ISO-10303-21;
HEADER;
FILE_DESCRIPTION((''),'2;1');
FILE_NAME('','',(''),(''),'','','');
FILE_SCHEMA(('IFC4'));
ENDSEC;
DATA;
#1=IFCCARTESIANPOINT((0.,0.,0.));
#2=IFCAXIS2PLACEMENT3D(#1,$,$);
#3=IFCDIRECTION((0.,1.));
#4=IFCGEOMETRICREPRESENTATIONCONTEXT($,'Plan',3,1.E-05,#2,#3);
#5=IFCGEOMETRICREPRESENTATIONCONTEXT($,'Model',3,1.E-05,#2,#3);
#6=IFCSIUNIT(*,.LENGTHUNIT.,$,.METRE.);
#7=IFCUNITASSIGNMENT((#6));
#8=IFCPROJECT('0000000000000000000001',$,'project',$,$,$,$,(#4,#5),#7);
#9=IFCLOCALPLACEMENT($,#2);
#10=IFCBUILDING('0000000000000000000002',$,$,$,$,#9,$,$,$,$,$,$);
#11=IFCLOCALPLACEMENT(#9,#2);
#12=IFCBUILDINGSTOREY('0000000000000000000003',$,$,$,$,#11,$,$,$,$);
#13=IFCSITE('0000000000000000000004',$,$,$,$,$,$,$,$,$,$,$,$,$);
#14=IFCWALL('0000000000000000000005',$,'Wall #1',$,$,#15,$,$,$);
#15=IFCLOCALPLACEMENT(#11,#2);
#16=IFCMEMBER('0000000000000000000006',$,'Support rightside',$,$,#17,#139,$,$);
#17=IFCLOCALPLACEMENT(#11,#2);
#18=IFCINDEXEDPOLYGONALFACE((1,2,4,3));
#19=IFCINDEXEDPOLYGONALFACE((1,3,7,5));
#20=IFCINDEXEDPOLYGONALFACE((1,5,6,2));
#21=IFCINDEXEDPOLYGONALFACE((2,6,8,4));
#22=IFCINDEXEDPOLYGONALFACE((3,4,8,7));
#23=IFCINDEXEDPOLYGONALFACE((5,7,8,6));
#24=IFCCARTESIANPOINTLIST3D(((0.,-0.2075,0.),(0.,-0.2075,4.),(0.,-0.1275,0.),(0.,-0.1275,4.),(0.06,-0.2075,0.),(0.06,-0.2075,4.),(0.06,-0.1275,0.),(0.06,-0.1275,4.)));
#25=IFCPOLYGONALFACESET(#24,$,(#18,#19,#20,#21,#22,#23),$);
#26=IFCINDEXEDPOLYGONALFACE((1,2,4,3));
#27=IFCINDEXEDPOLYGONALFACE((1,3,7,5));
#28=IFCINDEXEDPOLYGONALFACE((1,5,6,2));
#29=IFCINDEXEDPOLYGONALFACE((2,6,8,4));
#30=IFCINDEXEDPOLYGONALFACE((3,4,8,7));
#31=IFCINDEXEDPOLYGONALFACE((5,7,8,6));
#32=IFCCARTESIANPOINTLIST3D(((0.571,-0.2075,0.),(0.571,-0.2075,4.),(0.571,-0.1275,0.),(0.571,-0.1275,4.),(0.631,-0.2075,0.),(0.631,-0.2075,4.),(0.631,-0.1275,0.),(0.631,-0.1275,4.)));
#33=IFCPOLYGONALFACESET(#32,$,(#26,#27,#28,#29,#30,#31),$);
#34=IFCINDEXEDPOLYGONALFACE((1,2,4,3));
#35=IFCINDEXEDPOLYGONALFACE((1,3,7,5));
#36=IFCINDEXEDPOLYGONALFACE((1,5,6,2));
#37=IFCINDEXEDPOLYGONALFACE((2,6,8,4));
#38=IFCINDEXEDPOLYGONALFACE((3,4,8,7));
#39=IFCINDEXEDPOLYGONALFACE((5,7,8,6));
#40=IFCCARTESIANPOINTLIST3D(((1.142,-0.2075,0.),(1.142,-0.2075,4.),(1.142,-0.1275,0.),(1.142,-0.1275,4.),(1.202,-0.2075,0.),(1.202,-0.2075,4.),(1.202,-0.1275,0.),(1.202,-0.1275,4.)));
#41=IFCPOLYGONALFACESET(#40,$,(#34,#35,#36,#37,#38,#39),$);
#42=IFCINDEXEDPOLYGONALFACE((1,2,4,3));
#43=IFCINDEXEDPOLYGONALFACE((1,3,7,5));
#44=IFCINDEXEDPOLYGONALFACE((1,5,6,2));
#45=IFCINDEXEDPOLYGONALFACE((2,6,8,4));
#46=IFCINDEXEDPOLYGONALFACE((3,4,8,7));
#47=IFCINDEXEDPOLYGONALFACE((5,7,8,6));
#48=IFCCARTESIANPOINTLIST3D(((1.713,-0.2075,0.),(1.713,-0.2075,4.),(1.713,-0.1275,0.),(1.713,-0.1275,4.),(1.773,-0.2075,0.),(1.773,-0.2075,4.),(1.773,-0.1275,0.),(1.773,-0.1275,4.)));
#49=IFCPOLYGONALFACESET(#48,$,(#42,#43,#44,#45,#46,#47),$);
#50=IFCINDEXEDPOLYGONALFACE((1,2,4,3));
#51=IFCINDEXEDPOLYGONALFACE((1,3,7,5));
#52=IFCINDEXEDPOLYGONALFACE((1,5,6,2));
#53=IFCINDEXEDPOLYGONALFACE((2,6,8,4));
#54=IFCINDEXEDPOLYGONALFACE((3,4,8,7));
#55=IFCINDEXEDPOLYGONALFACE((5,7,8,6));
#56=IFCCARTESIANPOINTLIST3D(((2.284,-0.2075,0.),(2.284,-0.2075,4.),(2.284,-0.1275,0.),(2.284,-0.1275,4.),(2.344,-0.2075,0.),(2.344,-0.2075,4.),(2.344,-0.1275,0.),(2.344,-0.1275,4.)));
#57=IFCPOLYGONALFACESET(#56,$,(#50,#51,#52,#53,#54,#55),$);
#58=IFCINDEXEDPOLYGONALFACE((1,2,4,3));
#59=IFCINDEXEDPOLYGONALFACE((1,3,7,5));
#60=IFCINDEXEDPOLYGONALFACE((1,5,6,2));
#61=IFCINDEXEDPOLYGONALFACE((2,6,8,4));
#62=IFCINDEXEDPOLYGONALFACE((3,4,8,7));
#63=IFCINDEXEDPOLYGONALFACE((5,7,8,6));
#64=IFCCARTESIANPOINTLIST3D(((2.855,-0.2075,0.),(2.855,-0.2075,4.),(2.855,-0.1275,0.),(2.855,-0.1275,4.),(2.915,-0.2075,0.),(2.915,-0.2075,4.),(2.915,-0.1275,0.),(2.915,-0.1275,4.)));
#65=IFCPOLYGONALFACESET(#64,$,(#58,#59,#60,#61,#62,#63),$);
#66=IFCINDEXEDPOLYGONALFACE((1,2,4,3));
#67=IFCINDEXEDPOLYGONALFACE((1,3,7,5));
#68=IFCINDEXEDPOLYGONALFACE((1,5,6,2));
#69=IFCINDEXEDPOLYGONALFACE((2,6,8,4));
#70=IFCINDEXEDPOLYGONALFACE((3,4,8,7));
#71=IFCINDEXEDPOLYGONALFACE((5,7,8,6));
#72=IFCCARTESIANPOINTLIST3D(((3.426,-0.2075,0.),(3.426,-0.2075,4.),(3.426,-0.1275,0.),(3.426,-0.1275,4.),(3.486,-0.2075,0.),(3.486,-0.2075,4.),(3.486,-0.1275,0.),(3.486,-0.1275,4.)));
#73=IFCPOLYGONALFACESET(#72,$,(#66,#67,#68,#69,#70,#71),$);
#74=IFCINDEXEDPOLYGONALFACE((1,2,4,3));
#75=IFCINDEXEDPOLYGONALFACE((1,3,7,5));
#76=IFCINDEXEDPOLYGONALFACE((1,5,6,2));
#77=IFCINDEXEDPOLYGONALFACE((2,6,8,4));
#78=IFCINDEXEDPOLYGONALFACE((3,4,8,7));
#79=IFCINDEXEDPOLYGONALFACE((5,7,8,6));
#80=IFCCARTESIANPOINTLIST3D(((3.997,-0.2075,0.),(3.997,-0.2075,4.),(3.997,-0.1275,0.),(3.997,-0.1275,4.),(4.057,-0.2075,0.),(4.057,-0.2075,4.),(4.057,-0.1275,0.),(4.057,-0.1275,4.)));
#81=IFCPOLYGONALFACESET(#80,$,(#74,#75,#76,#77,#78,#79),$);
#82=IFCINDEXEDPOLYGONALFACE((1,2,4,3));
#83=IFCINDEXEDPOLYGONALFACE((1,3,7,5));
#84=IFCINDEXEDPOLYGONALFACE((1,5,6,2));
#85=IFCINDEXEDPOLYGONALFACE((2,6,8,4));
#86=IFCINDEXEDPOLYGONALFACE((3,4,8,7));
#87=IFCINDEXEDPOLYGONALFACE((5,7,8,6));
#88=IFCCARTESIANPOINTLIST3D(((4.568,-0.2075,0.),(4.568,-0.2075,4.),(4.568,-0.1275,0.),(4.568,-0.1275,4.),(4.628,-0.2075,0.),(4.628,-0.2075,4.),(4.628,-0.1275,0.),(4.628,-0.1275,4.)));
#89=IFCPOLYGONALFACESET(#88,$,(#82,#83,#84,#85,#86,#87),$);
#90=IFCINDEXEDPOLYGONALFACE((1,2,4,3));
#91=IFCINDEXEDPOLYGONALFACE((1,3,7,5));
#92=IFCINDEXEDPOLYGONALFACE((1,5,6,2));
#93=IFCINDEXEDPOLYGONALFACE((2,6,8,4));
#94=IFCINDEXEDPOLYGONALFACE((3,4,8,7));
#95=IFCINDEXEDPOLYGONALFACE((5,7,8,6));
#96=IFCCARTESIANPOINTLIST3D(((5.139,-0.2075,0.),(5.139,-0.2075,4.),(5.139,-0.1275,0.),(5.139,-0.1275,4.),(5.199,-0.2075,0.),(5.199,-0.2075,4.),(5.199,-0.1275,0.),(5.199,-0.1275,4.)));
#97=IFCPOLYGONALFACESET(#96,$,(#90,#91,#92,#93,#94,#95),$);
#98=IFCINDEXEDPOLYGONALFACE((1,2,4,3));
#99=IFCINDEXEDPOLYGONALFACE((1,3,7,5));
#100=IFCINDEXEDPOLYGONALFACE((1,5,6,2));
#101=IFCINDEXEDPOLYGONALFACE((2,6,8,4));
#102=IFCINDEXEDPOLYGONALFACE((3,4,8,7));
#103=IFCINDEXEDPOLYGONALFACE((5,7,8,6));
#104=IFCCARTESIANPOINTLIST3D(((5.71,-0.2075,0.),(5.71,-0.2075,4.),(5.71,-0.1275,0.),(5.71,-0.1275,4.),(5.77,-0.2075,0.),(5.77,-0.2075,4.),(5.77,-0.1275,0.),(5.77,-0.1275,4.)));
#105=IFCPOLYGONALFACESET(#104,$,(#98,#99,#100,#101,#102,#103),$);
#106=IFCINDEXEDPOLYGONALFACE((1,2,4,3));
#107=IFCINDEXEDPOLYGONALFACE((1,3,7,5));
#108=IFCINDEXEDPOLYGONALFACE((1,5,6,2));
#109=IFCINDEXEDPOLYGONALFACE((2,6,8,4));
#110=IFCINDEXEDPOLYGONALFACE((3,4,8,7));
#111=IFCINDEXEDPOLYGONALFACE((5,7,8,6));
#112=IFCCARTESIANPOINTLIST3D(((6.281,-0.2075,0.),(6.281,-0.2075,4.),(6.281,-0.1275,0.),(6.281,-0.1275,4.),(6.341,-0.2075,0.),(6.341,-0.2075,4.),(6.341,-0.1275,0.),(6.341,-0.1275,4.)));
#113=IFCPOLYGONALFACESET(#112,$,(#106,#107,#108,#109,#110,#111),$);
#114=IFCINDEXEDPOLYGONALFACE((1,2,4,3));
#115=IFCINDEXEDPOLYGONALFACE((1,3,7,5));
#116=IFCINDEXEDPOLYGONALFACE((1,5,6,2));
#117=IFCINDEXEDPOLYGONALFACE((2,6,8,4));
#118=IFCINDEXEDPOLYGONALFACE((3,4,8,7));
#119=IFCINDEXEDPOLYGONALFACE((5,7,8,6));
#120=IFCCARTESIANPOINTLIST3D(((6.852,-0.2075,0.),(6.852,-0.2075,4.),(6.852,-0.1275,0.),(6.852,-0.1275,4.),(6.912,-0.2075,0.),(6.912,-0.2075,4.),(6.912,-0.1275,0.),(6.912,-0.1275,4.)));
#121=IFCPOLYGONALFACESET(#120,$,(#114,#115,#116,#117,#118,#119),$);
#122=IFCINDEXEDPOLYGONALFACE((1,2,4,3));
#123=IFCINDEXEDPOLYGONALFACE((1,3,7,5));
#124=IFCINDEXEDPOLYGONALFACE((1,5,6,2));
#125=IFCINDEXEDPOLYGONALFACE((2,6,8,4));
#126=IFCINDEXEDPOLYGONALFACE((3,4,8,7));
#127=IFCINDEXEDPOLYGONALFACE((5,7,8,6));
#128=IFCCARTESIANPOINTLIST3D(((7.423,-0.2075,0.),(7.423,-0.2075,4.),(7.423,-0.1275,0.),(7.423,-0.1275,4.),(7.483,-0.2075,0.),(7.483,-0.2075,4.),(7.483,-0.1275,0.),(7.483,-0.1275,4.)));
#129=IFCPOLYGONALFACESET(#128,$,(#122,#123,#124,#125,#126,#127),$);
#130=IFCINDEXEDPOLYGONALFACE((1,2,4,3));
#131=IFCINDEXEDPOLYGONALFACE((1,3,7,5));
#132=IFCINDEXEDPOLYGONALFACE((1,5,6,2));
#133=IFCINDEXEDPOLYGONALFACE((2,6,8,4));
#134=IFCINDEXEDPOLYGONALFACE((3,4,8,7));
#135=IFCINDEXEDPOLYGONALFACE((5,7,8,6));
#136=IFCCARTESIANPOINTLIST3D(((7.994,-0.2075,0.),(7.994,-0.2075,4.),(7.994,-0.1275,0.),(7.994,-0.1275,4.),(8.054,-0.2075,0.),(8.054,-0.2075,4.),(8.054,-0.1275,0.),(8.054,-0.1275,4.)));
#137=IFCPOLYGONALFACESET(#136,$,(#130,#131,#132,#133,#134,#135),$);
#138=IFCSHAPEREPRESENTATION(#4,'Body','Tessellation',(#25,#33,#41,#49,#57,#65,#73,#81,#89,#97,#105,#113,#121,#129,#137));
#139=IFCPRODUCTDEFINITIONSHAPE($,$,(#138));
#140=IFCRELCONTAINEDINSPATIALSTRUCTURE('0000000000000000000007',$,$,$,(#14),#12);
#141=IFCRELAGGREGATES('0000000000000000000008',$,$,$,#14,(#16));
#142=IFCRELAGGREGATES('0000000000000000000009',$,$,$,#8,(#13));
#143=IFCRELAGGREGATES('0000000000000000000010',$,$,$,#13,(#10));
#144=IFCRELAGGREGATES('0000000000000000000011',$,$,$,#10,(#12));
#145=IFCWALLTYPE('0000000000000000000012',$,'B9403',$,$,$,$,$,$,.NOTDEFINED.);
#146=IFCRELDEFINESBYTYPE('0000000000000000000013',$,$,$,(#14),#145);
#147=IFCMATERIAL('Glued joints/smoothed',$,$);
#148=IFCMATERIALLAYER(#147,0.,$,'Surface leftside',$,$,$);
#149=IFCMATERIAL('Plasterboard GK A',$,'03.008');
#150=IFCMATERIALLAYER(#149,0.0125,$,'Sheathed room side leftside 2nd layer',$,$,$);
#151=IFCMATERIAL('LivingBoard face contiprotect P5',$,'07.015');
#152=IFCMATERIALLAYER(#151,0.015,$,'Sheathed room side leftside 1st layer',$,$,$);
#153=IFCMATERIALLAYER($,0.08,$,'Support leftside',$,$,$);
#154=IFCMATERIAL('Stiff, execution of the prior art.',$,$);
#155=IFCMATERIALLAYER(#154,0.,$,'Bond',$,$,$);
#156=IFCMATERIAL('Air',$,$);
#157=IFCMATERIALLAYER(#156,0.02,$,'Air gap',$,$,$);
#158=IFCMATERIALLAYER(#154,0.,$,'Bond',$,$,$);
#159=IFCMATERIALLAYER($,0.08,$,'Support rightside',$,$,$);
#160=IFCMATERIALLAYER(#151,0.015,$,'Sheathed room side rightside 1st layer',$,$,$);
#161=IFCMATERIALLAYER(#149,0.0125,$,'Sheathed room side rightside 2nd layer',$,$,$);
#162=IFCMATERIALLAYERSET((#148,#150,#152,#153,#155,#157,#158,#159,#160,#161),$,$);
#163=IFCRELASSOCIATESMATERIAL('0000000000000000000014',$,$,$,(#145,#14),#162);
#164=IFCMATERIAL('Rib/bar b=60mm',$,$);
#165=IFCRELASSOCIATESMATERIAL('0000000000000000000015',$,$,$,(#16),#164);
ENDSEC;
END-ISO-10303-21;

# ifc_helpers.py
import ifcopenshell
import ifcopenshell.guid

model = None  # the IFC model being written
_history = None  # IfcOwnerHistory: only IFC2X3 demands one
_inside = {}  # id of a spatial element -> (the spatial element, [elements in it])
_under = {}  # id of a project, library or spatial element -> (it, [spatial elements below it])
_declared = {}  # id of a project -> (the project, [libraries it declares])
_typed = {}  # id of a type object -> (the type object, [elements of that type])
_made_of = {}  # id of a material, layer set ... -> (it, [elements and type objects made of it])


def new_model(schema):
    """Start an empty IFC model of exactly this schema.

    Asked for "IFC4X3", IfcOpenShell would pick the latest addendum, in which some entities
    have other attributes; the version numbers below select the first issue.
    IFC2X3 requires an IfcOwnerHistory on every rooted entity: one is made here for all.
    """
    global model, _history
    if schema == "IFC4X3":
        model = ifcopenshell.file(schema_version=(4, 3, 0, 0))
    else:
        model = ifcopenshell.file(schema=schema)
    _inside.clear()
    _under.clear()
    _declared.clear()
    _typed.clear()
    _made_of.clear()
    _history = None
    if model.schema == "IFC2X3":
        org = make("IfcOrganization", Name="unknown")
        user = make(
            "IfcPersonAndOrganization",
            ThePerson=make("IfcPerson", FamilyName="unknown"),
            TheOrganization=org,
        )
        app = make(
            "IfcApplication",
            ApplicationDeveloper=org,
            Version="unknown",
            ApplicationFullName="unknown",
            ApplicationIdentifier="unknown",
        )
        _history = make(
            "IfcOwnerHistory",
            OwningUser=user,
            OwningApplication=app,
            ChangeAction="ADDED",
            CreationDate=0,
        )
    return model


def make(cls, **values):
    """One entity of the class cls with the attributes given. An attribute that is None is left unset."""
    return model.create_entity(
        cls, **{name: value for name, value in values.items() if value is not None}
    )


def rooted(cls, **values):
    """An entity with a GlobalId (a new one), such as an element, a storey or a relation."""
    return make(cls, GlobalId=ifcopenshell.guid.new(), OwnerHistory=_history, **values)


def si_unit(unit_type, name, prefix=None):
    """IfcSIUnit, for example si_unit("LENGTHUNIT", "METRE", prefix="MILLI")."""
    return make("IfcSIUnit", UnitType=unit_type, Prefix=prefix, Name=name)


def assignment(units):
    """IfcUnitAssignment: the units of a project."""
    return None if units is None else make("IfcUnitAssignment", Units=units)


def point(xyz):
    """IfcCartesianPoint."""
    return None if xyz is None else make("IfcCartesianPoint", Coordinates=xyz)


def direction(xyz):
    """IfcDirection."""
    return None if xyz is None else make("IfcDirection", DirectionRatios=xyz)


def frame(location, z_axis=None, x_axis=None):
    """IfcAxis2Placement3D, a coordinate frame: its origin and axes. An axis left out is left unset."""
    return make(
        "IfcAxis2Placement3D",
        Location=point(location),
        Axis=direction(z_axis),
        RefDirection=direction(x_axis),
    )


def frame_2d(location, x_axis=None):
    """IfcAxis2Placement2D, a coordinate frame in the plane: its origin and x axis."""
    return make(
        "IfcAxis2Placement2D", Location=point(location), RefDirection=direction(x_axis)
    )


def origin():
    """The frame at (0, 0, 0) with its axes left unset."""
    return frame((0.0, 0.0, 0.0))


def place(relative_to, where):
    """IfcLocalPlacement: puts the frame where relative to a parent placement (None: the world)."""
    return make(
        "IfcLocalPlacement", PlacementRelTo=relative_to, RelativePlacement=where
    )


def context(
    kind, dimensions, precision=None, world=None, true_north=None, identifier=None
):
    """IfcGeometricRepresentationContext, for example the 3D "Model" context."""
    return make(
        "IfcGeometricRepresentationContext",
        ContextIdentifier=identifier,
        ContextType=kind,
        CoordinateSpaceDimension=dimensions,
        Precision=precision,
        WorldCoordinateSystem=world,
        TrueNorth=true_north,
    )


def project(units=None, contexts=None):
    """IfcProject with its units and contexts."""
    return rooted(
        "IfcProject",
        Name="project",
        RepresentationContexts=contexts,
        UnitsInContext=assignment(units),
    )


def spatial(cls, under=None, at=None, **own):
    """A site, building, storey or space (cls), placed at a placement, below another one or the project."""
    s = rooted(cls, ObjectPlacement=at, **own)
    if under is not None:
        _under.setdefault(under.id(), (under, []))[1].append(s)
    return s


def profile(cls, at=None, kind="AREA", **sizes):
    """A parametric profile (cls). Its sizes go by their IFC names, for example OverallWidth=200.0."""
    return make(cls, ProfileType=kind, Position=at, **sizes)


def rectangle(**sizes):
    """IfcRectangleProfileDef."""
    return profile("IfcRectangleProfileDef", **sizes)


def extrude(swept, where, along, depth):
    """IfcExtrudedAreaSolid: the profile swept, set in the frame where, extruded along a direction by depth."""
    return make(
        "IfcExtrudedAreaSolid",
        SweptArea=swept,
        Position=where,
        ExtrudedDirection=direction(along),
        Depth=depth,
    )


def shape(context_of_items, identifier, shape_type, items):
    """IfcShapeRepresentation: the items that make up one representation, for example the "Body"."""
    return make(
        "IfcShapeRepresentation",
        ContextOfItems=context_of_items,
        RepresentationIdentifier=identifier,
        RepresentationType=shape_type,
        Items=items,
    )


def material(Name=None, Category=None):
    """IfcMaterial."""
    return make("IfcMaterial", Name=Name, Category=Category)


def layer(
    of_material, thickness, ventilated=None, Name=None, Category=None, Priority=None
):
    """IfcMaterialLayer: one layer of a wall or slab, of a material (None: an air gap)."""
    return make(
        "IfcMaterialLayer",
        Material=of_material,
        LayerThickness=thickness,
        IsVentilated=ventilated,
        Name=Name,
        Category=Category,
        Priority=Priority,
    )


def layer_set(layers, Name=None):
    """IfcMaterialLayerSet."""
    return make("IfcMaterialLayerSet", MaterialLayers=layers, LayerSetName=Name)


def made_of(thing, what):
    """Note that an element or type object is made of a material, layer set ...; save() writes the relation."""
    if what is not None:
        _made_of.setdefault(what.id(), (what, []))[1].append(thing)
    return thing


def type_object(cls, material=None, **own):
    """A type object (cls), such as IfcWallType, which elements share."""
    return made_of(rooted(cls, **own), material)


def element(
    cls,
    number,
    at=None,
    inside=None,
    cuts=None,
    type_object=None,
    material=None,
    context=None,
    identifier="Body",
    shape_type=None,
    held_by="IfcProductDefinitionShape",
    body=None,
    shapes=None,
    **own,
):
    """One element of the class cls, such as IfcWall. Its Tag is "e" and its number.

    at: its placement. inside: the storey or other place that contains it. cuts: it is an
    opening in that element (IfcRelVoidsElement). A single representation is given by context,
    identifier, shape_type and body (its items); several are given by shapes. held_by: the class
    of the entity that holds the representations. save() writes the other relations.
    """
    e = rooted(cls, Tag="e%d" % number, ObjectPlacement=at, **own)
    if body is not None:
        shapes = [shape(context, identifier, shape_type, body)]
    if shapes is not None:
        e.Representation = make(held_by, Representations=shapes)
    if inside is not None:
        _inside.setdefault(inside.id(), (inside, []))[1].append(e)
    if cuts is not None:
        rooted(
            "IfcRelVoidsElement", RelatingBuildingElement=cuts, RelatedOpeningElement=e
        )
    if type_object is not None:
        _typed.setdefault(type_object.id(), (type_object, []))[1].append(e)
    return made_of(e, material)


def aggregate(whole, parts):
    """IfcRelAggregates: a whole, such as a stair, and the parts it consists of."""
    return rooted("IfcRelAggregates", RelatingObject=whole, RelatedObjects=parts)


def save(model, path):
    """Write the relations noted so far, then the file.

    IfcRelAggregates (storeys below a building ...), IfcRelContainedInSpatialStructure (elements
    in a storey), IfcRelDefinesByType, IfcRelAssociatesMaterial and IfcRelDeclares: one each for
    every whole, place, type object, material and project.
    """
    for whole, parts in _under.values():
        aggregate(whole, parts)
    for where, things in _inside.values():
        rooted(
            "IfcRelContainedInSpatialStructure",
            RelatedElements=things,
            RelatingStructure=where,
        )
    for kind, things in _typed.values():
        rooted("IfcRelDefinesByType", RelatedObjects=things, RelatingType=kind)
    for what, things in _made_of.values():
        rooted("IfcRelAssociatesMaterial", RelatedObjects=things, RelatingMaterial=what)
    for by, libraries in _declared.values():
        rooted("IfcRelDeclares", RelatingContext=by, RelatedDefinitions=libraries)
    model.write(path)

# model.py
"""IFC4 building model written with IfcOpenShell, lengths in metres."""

from ifc_helpers import new_model, si_unit, direction, frame, frame_2d, origin, place, context, project, spatial, rectangle, extrude, material, layer, layer_set, type_object, element, aggregate, save


model = new_model("IFC4")

# Units and contexts
plan_context = context("Plan", 3, precision=1e-05, world=origin(), true_north=direction((0.0, 1.0)))
model_context = context("Model", 3, precision=1e-05, world=origin(), true_north=direction((0.0, 1.0)))
ifc_project = project(units=[si_unit("LENGTHUNIT", "METRE")], contexts=[plan_context, model_context])

# Site, building, storey
site = spatial("IfcSite", under=ifc_project)
building_placement = place(None, origin())
building = spatial("IfcBuilding", under=site, at=building_placement)
storey_placement = place(building_placement, origin())
storey = spatial("IfcBuildingStorey", under=building, at=storey_placement)

# Wall, member
ifc_material_1 = material(Name="Glued joints/smoothed")
ifc_layer_1 = layer(ifc_material_1, 0.0, Name="Surface leftside")
ifc_material_2 = material(Name="Plasterboard GK A", Category="03.008")
ifc_layer_2 = layer(ifc_material_2, 0.0125, Name="Sheathed room side leftside 2nd layer")
ifc_material_3 = material(Name="LivingBoard face contiprotect P5", Category="07.015")
ifc_layer_3 = layer(ifc_material_3, 0.015, Name="Sheathed room side leftside 1st layer")
ifc_layer_4 = layer(None, 0.08, Name="Support leftside")
ifc_material_4 = material(Name="Stiff, execution of the prior art.")
ifc_layer_5 = layer(ifc_material_4, 0.0, Name="Bond")
ifc_material_5 = material(Name="Air")
ifc_layer_6 = layer(ifc_material_5, 0.02, Name="Air gap")
ifc_layer_7 = layer(ifc_material_4, 0.0, Name="Bond")
ifc_layer_8 = layer(None, 0.08, Name="Support rightside")
ifc_layer_9 = layer(ifc_material_3, 0.015, Name="Sheathed room side rightside 1st layer")
ifc_layer_10 = layer(ifc_material_2, 0.0125, Name="Sheathed room side rightside 2nd layer")
ifc_layer_set = layer_set([ifc_layer_1, ifc_layer_2, ifc_layer_3, ifc_layer_4, ifc_layer_5, ifc_layer_6, ifc_layer_7, ifc_layer_8, ifc_layer_9, ifc_layer_10])
wall_type = type_object("IfcWallType", Name="B9403", PredefinedType="NOTDEFINED", material=ifc_layer_set)
wall_placement = place(None, frame((0.0, 0.0, 0.0), z_axis=(0.0, -1.0, 0.0), x_axis=(1.0, 0.0, 0.0)))
wall = element("IfcWall", 1, at=wall_placement, inside=storey, type_object=wall_type, material=ifc_layer_set, Name="Wall #1")
ifc_material_6 = material(Name="Rib/bar b=60mm")
member_1_placement = place(wall_placement, origin())
member_1 = element("IfcMember", 2, at=member_1_placement, material=ifc_material_6, Name="Support rightside", context=plan_context, shape_type="SweptSolid", body=[
    extrude(rectangle(XDim=0.06, YDim=0.08, at=frame_2d((0.03, 0.04), x_axis=(1.0, 0.0))), frame((0.0, 4.0, 0.1275), z_axis=(0.0, -1.0, 0.0), x_axis=(1.0, 0.0, 0.0)), (0.0, 0.0, 1.0), 4.0),
    extrude(rectangle(XDim=0.06, YDim=0.08, at=frame_2d((0.03, 0.04), x_axis=(1.0, 0.0))), frame((0.571, 4.0, 0.1275), z_axis=(0.0, -1.0, 0.0), x_axis=(1.0, 0.0, 0.0)), (0.0, 0.0, 1.0), 4.0),
    extrude(rectangle(XDim=0.06, YDim=0.08, at=frame_2d((0.03, 0.04), x_axis=(1.0, 0.0))), frame((1.142, 4.0, 0.1275), z_axis=(0.0, -1.0, 0.0), x_axis=(1.0, 0.0, 0.0)), (0.0, 0.0, 1.0), 4.0),
    extrude(rectangle(XDim=0.06, YDim=0.08, at=frame_2d((0.03, 0.04), x_axis=(1.0, 0.0))), frame((1.713, 4.0, 0.1275), z_axis=(0.0, -1.0, 0.0), x_axis=(1.0, 0.0, 0.0)), (0.0, 0.0, 1.0), 4.0),
    extrude(rectangle(XDim=0.06, YDim=0.08, at=frame_2d((0.03, 0.04), x_axis=(1.0, 0.0))), frame((2.284, 4.0, 0.1275), z_axis=(0.0, -1.0, 0.0), x_axis=(1.0, 0.0, 0.0)), (0.0, 0.0, 1.0), 4.0),
    extrude(rectangle(XDim=0.06, YDim=0.08, at=frame_2d((0.03, 0.04), x_axis=(1.0, 0.0))), frame((2.855, 4.0, 0.1275), z_axis=(0.0, -1.0, 0.0), x_axis=(1.0, 0.0, 0.0)), (0.0, 0.0, 1.0), 4.0),
    extrude(rectangle(XDim=0.06, YDim=0.08, at=frame_2d((0.03, 0.04), x_axis=(1.0, 0.0))), frame((3.426, 4.0, 0.1275), z_axis=(0.0, -1.0, 0.0), x_axis=(1.0, 0.0, 0.0)), (0.0, 0.0, 1.0), 4.0),
    extrude(rectangle(XDim=0.06, YDim=0.08, at=frame_2d((0.03, 0.04), x_axis=(1.0, 0.0))), frame((3.997, 4.0, 0.1275), z_axis=(0.0, -1.0, 0.0), x_axis=(1.0, 0.0, 0.0)), (0.0, 0.0, 1.0), 4.0),
    extrude(rectangle(XDim=0.06, YDim=0.08, at=frame_2d((0.03, 0.04), x_axis=(1.0, 0.0))), frame((4.568, 4.0, 0.1275), z_axis=(0.0, -1.0, 0.0), x_axis=(1.0, 0.0, 0.0)), (0.0, 0.0, 1.0), 4.0),
    extrude(rectangle(XDim=0.06, YDim=0.08, at=frame_2d((0.03, 0.04), x_axis=(1.0, 0.0))), frame((5.139, 4.0, 0.1275), z_axis=(0.0, -1.0, 0.0), x_axis=(1.0, 0.0, 0.0)), (0.0, 0.0, 1.0), 4.0),
    extrude(rectangle(XDim=0.06, YDim=0.08, at=frame_2d((0.03, 0.04), x_axis=(1.0, 0.0))), frame((5.71, 4.0, 0.1275), z_axis=(0.0, -1.0, 0.0), x_axis=(1.0, 0.0, 0.0)), (0.0, 0.0, 1.0), 4.0),
    extrude(rectangle(XDim=0.06, YDim=0.08, at=frame_2d((0.03, 0.04), x_axis=(1.0, 0.0))), frame((6.281, 4.0, 0.1275), z_axis=(0.0, -1.0, 0.0), x_axis=(1.0, 0.0, 0.0)), (0.0, 0.0, 1.0), 4.0),
    extrude(rectangle(XDim=0.06, YDim=0.08, at=frame_2d((0.03, 0.04), x_axis=(1.0, 0.0))), frame((6.852, 4.0, 0.1275), z_axis=(0.0, -1.0, 0.0), x_axis=(1.0, 0.0, 0.0)), (0.0, 0.0, 1.0), 4.0),
    extrude(rectangle(XDim=0.06, YDim=0.08, at=frame_2d((0.03, 0.04), x_axis=(1.0, 0.0))), frame((7.423, 4.0, 0.1275), z_axis=(0.0, -1.0, 0.0), x_axis=(1.0, 0.0, 0.0)), (0.0, 0.0, 1.0), 4.0),
    extrude(rectangle(XDim=0.06, YDim=0.08, at=frame_2d((0.03, 0.04), x_axis=(1.0, 0.0))), frame((7.994, 4.0, 0.1275), z_axis=(0.0, -1.0, 0.0), x_axis=(1.0, 0.0, 0.0)), (0.0, 0.0, 1.0), 4.0),
])
aggregate(wall, [member_1])

save(model, "model.ifc")
